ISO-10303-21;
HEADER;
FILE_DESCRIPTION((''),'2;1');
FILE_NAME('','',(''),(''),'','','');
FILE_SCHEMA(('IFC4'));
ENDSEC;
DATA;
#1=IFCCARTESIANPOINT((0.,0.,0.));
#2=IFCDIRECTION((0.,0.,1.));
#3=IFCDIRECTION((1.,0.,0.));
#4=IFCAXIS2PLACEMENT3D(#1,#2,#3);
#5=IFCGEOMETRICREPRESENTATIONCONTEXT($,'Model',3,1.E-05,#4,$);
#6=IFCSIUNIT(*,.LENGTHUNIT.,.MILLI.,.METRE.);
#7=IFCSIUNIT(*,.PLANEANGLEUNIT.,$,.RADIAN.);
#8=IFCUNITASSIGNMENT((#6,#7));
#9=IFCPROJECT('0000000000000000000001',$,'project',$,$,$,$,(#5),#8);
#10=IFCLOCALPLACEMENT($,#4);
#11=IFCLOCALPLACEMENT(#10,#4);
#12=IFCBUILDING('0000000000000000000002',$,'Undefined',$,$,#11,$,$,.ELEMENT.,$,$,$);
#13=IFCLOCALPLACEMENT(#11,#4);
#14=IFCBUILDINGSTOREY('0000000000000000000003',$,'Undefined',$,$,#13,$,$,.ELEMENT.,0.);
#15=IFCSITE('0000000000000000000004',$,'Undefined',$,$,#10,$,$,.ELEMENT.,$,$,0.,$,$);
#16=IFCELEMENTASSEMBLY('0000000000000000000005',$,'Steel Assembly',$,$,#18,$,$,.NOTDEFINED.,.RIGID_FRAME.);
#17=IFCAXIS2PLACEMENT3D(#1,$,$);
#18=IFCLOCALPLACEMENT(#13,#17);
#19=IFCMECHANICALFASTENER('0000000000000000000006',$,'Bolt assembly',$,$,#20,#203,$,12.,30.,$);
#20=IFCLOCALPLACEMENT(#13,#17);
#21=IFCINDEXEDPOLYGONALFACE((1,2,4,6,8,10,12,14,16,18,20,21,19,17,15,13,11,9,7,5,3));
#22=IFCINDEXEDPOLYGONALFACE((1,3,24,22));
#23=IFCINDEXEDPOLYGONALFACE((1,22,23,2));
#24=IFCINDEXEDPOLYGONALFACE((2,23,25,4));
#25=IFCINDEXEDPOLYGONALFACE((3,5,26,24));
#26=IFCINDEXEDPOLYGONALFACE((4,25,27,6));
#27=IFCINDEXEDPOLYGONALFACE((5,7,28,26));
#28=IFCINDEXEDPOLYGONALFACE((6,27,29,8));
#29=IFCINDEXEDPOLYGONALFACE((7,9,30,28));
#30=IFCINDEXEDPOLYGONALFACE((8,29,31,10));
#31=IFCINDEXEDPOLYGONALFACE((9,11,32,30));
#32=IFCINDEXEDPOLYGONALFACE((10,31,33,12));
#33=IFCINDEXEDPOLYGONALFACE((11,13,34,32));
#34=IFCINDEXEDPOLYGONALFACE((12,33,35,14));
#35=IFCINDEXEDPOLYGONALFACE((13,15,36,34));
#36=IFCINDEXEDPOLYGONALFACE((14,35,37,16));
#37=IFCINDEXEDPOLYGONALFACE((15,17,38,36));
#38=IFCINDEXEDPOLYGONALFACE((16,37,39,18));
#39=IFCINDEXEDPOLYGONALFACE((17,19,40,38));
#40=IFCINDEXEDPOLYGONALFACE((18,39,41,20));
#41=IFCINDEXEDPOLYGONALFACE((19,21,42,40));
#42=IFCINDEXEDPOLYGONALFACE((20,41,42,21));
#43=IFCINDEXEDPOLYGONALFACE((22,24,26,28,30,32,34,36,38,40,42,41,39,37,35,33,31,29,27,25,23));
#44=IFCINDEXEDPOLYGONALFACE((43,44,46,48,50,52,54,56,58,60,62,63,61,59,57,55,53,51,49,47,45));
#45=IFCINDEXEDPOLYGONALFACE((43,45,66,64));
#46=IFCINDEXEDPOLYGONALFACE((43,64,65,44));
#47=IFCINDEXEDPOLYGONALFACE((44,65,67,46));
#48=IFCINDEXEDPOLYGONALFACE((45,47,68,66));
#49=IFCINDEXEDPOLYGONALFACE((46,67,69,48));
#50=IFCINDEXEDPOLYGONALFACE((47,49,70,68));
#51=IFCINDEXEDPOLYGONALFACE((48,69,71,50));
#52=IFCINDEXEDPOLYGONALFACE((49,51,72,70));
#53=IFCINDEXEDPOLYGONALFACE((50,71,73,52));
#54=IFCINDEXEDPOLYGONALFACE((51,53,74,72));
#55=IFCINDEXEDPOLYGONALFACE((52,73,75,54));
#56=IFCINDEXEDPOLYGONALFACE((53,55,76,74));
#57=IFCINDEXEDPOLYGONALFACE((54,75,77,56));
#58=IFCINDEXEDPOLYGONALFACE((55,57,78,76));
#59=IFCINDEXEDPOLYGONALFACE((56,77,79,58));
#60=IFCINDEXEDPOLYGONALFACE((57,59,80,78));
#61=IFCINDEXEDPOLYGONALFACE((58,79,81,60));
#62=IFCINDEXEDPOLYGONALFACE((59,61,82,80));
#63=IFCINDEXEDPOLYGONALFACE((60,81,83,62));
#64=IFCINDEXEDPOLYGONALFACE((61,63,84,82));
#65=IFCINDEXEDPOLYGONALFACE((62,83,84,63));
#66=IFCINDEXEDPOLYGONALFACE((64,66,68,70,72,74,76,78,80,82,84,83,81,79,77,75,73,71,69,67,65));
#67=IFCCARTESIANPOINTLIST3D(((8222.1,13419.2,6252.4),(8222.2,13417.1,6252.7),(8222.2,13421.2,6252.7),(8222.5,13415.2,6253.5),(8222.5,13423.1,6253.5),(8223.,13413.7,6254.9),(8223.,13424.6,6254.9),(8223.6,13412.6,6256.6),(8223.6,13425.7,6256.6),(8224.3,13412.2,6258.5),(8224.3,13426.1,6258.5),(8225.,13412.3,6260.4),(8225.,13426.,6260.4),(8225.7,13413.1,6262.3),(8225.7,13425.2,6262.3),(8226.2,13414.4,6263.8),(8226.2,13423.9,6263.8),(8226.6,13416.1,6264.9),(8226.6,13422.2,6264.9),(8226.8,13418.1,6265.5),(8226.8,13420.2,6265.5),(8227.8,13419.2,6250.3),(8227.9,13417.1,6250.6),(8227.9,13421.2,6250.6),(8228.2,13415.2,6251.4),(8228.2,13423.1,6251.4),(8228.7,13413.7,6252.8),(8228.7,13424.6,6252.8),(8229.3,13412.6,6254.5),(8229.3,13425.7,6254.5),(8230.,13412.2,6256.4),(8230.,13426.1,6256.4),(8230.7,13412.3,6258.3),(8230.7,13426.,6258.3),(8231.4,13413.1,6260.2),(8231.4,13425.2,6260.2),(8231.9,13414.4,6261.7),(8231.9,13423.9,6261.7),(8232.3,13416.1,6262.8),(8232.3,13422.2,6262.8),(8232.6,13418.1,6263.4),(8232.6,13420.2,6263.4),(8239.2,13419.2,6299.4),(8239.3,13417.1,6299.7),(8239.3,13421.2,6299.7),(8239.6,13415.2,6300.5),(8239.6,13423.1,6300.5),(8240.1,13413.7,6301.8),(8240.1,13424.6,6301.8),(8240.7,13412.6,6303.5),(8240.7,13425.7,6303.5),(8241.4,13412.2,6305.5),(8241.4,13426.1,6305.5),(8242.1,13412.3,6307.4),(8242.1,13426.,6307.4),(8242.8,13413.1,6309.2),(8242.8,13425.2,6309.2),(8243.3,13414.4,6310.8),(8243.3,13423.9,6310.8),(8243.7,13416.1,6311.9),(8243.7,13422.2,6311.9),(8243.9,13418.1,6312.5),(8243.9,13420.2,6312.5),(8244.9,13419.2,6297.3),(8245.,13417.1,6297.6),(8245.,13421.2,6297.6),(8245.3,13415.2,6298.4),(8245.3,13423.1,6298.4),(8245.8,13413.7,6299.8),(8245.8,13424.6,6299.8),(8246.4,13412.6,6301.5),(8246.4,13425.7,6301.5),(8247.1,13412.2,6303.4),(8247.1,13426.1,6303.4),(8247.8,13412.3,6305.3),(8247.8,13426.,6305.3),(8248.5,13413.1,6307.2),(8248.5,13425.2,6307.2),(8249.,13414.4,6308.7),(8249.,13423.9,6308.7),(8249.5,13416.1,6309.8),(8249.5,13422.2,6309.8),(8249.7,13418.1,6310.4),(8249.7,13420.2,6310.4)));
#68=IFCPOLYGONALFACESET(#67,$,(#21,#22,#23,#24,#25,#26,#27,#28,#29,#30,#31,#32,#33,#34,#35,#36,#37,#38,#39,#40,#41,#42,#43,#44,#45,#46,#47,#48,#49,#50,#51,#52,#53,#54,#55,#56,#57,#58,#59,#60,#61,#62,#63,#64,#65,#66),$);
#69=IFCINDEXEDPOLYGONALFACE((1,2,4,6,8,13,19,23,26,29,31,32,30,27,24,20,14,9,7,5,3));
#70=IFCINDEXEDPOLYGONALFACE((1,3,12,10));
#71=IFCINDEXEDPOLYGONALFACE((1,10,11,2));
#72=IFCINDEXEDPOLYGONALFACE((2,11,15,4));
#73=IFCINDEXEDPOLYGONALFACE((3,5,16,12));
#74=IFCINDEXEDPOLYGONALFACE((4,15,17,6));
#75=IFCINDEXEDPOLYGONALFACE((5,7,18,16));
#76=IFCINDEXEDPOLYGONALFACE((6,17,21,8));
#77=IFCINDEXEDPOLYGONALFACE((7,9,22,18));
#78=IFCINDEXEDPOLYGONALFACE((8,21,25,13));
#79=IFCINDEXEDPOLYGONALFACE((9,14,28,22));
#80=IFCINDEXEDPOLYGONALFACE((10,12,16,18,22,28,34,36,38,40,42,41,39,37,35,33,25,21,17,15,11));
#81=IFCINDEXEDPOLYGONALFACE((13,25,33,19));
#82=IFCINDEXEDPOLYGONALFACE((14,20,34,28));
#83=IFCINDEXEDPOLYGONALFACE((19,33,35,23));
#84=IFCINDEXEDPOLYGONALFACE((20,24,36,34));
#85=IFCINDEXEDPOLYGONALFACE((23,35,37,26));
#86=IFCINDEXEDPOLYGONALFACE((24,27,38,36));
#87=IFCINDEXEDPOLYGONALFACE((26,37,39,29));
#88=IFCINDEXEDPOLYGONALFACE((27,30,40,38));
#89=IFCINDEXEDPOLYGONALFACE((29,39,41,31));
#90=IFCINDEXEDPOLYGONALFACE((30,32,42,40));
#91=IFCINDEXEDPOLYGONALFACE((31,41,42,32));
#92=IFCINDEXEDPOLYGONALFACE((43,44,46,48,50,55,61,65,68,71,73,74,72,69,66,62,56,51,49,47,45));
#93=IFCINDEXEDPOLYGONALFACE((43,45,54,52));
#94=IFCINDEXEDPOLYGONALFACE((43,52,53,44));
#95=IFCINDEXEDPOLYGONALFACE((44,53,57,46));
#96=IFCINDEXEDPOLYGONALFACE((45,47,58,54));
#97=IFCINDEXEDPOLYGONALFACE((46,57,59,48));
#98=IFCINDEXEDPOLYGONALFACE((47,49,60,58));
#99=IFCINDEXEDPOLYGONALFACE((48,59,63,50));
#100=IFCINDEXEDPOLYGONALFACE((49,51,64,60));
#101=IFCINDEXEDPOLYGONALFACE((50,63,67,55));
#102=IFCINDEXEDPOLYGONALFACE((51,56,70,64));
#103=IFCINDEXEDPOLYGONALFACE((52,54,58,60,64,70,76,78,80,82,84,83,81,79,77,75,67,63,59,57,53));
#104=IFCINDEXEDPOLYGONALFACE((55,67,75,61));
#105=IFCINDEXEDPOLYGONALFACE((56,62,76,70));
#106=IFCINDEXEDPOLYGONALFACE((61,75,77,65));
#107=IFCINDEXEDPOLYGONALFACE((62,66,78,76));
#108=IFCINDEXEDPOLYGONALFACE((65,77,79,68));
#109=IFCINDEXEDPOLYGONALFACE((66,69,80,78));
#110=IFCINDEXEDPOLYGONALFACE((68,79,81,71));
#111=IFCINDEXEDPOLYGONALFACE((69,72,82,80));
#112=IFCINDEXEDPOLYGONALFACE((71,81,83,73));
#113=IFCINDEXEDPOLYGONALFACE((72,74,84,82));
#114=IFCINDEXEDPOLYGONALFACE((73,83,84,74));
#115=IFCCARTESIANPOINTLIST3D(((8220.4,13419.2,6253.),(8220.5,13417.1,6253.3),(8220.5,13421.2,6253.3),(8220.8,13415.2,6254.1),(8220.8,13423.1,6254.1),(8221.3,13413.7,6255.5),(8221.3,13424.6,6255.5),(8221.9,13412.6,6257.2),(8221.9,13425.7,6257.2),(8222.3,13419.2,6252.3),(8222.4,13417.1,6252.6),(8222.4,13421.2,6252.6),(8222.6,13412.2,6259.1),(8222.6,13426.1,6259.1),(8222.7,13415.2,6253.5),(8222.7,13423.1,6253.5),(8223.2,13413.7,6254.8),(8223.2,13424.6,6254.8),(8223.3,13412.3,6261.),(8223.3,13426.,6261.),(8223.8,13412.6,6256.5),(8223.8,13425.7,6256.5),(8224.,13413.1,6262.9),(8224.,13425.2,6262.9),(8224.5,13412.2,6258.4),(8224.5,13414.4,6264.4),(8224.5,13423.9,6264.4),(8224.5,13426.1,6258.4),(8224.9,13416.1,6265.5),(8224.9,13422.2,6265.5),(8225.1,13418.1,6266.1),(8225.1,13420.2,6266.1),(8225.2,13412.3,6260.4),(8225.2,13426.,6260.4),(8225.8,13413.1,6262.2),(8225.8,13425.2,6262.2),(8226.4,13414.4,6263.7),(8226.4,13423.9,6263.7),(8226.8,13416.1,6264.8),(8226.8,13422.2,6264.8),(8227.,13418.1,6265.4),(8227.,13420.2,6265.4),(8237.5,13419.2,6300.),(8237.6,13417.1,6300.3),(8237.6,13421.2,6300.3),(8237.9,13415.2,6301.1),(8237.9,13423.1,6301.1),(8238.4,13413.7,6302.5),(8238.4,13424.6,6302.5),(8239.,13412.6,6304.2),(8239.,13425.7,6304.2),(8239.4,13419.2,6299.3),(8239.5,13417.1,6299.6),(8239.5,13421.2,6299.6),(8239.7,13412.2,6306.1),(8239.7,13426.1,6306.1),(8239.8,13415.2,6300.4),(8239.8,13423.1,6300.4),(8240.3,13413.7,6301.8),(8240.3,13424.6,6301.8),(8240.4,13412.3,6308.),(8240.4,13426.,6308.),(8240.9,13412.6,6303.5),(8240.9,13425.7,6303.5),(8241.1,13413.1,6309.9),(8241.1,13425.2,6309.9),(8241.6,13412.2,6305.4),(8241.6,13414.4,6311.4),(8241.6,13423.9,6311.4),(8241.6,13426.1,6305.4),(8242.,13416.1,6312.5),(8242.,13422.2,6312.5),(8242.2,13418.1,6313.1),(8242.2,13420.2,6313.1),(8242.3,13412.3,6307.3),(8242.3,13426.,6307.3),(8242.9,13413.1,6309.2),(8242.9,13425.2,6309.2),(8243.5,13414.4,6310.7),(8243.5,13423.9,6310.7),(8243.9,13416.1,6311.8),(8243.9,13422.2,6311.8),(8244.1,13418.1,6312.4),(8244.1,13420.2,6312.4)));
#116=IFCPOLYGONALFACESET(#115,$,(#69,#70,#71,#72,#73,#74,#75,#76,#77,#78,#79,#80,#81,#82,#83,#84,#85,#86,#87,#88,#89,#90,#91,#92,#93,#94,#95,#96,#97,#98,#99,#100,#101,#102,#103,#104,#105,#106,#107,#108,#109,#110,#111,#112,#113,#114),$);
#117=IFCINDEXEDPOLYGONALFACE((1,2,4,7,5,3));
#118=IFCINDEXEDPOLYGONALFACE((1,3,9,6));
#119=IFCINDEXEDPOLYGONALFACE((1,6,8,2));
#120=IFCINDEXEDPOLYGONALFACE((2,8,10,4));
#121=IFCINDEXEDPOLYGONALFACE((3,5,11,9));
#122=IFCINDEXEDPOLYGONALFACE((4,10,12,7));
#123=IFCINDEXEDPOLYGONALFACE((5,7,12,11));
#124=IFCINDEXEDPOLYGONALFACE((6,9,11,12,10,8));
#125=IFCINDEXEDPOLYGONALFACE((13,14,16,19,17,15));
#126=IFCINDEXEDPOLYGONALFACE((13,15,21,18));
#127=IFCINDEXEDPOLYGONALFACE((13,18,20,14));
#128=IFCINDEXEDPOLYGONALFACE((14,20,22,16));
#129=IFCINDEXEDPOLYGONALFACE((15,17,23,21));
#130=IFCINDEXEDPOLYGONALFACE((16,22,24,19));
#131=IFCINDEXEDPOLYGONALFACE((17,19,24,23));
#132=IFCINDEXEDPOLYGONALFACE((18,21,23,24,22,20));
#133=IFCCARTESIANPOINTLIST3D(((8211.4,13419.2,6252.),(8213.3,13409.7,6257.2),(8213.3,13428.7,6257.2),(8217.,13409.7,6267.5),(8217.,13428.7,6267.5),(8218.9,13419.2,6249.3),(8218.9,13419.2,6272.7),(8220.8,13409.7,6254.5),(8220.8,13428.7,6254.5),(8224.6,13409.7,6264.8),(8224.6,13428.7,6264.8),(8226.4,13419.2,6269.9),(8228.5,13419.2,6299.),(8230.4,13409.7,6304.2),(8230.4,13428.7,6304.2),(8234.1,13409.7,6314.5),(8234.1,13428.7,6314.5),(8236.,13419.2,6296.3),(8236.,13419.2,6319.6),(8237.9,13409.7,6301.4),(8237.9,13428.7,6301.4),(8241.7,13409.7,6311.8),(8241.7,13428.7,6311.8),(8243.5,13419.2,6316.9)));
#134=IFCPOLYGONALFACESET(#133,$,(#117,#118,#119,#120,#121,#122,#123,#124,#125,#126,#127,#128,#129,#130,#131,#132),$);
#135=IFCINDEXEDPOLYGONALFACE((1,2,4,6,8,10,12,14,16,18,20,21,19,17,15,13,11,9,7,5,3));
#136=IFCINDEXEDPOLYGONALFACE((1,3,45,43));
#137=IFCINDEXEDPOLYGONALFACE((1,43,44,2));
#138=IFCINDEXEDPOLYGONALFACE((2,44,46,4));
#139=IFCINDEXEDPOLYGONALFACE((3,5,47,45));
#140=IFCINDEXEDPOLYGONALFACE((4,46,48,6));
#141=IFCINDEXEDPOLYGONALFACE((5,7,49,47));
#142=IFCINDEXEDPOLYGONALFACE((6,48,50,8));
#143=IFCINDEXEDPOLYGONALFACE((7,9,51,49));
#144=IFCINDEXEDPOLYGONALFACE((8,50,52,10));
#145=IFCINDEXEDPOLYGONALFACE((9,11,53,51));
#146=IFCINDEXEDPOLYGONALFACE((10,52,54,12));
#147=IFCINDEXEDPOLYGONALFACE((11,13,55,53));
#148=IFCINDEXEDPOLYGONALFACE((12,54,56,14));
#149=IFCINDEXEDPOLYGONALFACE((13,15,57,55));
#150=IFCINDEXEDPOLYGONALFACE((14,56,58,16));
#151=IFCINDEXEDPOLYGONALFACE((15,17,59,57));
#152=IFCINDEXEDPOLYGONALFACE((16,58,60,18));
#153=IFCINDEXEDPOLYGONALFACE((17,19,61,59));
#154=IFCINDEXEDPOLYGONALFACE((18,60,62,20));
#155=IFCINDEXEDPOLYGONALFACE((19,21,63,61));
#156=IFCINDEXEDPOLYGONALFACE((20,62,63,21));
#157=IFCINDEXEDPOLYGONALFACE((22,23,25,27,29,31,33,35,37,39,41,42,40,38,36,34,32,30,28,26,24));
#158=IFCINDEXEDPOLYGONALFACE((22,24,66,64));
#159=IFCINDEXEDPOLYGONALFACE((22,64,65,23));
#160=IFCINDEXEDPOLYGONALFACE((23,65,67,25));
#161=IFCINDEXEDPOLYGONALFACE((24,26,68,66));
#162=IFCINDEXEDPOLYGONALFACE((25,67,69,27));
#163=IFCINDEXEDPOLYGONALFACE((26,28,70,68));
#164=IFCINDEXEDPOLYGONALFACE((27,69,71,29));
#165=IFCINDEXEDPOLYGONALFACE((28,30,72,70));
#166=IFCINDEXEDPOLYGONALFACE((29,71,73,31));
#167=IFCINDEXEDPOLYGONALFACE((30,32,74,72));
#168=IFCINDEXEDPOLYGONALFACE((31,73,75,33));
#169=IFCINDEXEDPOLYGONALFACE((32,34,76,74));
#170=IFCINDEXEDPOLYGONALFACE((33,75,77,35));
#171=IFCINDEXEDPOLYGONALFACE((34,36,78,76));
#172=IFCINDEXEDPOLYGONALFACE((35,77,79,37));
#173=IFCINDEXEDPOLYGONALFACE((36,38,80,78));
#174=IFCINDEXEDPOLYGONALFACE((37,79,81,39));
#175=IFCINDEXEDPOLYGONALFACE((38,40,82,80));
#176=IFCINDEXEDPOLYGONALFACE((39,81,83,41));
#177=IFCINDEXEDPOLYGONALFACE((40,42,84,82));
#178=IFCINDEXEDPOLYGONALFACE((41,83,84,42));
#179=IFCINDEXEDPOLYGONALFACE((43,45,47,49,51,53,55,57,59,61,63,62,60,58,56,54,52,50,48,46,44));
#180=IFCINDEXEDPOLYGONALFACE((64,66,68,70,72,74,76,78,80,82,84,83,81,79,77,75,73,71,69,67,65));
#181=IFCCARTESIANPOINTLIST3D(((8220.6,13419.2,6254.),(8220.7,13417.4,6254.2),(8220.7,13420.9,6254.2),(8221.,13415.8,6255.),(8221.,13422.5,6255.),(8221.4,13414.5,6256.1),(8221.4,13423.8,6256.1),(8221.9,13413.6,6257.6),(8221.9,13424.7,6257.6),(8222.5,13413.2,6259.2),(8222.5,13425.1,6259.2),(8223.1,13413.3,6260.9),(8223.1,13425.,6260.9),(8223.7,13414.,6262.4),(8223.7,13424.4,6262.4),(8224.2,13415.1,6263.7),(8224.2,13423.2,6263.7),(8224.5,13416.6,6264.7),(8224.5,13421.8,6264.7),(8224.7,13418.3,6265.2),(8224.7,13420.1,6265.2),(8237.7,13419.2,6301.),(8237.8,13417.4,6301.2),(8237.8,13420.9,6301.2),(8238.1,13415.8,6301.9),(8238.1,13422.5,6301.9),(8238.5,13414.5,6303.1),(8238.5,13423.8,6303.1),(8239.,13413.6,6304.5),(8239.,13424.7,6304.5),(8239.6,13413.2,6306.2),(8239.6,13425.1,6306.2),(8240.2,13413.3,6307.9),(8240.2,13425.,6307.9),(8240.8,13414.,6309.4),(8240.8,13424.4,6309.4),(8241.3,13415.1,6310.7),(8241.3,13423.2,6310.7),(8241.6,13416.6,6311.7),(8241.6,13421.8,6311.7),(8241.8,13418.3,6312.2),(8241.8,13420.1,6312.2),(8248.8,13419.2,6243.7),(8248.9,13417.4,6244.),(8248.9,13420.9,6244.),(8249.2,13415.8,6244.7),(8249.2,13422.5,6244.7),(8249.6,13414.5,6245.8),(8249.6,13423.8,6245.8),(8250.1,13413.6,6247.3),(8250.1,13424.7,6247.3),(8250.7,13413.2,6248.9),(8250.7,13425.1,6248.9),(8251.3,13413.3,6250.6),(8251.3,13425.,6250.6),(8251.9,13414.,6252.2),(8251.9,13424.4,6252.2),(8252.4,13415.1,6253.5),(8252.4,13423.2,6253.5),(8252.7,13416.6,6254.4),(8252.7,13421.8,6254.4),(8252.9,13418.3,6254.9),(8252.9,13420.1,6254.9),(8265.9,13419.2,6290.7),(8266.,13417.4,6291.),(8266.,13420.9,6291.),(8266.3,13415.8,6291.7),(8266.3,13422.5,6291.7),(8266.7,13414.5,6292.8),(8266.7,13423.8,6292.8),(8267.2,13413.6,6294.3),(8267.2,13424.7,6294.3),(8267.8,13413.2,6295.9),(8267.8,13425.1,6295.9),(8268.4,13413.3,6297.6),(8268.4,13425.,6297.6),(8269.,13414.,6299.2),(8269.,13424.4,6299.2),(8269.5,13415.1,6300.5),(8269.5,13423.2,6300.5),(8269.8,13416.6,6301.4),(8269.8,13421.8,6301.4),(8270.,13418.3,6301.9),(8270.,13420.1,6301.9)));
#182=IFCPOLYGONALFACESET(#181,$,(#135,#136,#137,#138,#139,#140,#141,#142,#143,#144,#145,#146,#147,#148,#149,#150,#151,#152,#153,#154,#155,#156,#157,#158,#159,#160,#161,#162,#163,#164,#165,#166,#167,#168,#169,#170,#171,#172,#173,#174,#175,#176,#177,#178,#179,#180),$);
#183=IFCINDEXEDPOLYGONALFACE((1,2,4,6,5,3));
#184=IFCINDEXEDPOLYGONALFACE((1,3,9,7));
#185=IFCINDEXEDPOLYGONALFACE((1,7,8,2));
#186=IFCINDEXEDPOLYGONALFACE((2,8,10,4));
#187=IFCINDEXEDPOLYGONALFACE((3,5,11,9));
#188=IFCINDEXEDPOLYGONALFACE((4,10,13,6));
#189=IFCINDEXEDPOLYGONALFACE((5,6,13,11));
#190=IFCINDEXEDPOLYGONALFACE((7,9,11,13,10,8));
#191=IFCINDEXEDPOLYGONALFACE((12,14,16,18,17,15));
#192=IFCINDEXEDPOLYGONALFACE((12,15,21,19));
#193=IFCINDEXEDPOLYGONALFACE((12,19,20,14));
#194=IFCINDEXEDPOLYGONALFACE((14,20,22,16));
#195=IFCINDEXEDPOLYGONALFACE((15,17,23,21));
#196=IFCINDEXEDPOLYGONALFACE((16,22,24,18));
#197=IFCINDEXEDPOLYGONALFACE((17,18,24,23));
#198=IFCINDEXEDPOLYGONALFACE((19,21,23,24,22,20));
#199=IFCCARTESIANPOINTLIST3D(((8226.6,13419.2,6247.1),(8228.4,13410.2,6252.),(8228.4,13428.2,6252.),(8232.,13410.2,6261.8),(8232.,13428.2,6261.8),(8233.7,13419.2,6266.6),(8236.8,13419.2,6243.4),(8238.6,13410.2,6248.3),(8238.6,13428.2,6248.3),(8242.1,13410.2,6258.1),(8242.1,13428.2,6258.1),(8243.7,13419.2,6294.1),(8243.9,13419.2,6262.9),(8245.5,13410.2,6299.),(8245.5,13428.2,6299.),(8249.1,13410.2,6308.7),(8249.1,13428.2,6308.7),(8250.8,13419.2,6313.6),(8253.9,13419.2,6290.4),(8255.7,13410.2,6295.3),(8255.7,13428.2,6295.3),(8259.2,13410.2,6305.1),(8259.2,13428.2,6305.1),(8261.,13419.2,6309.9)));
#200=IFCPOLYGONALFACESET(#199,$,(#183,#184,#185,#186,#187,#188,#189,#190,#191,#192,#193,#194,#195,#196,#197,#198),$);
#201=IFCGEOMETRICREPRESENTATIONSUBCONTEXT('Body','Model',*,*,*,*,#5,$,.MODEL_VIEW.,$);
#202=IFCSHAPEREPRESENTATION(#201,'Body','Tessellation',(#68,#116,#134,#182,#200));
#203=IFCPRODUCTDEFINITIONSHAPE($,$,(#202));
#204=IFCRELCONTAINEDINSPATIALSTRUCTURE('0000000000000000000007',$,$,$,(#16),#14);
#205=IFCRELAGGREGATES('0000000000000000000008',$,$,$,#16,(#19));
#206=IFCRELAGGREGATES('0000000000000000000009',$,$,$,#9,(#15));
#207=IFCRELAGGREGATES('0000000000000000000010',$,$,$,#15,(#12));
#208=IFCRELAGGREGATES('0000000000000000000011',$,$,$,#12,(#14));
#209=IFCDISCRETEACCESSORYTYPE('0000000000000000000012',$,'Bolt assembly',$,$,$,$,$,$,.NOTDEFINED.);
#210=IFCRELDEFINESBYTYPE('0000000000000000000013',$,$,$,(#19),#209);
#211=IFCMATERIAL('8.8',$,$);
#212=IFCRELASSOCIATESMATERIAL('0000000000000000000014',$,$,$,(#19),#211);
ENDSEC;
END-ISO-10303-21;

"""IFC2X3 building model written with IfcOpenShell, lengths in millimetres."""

from ifc_helpers import new_model, si_unit, frame, origin_with_axes, origin_2d_with_axis, place, context, subcontext, project, spatial, polyline, circle, outline, extrude, source, transform, mapped, material, type_object, element, aggregate, save


model = new_model("IFC2X3")

# Units and contexts
model_context = context("Model", 3, precision=1e-05, world=origin_with_axes())
body_context = subcontext(model_context, "Body", "Model", "MODEL_VIEW")
ifc_project = project(units=[si_unit("LENGTHUNIT", "METRE", prefix="MILLI"), si_unit("PLANEANGLEUNIT", "RADIAN")], contexts=[model_context])

# Site, building, storey
site_placement = place(None, origin_with_axes())
site = spatial("IfcSite", under=ifc_project, at=site_placement, Name="Undefined", CompositionType="ELEMENT", RefElevation=0.0)
building_placement = place(site_placement, origin_with_axes())
building = spatial("IfcBuilding", under=site, at=building_placement, Name="Undefined", CompositionType="ELEMENT")
storey_placement = place(building_placement, origin_with_axes())
storey = spatial("IfcBuildingStorey", under=building, at=storey_placement, Name="Undefined", CompositionType="ELEMENT", Elevation=0.0)

# Shared definitions
ifc_material_1 = material(Name="8.8")
discrete_accessory_type_1 = type_object("IfcDiscreteAccessoryType", Name="Bolt assembly")

# Element assembly, mechanical fastener
assembly_1_placement = place(storey_placement, origin_with_axes())
assembly_1 = element("IfcElementAssembly", 1, at=assembly_1_placement, inside=storey, Name="Steel Assembly", AssemblyPlace="NOTDEFINED", PredefinedType="RIGID_FRAME")
shared_shape_1 = source(origin_with_axes(), body_context, "Body", "SweptSolid", [
    extrude(circle(Radius=7.0, at=origin_2d_with_axis()), frame((0.0, -6.1, 0.0), z_axis=(0.0, 1.0, 0.0), x_axis=(1.0, 0.0, 0.0)), (0.0, 0.0, 1.0), 6.1),
    extrude(circle(Radius=7.0, at=origin_2d_with_axis()), frame((0.0, -7.9, 0.0), z_axis=(0.0, 1.0, 0.0), x_axis=(1.0, 0.0, 0.0)), (0.0, 0.0, 1.0), 2.0),
    extrude(outline(polyline([(11.0, 0.0), (5.5, 9.5), (-5.5, 9.5), (-11.0, 0.0), (-5.5, -9.5), (5.5, -9.5), (11.0, 0.0)])), frame((0.0, -16.0, 0.0), z_axis=(0.0, 1.0, 0.0), x_axis=(1.0, 0.0, 0.0)), (0.0, 0.0, 1.0), 8.0),
    extrude(circle(Radius=6.0, at=origin_2d_with_axis()), frame((0.0, -8.0, 0.0), z_axis=(0.0, 1.0, 0.0), x_axis=(1.0, 0.0, 0.0)), (0.0, 0.0, 1.0), 30.0),
    extrude(outline(polyline([(10.4, 0.0), (5.2, 9.0), (-5.2, 9.0), (-10.4, 0.0), (-5.2, -9.0), (5.2, -9.0), (10.4, 0.0)])), frame((0.0, 0.0, 0.0), z_axis=(0.0, 1.0, 0.0), x_axis=(1.0, 0.0, 0.0)), (0.0, 0.0, 1.0), 10.8),
])
mechanical_fastener_1_placement = place(assembly_1_placement, frame((8247.3, 13419.2, 6303.9), z_axis=(0.0, -1.0, 0.0), x_axis=(-0.34202, 0.0, -0.939693)))
mechanical_fastener_1 = element("IfcMechanicalFastener", 2, at=mechanical_fastener_1_placement, type_object=discrete_accessory_type_1, material=ifc_material_1, Name="Bolt assembly", NominalDiameter=12.0, NominalLength=30.0, context=body_context, shape_type="MappedRepresentation", body=[
    mapped(shared_shape_1, transform((0.0, 0.0, 0.0))),
    mapped(shared_shape_1, transform((50.0, 0.0, 0.0))),
])
aggregate(assembly_1, [mechanical_fastener_1])

save(model, "model.ifc")
